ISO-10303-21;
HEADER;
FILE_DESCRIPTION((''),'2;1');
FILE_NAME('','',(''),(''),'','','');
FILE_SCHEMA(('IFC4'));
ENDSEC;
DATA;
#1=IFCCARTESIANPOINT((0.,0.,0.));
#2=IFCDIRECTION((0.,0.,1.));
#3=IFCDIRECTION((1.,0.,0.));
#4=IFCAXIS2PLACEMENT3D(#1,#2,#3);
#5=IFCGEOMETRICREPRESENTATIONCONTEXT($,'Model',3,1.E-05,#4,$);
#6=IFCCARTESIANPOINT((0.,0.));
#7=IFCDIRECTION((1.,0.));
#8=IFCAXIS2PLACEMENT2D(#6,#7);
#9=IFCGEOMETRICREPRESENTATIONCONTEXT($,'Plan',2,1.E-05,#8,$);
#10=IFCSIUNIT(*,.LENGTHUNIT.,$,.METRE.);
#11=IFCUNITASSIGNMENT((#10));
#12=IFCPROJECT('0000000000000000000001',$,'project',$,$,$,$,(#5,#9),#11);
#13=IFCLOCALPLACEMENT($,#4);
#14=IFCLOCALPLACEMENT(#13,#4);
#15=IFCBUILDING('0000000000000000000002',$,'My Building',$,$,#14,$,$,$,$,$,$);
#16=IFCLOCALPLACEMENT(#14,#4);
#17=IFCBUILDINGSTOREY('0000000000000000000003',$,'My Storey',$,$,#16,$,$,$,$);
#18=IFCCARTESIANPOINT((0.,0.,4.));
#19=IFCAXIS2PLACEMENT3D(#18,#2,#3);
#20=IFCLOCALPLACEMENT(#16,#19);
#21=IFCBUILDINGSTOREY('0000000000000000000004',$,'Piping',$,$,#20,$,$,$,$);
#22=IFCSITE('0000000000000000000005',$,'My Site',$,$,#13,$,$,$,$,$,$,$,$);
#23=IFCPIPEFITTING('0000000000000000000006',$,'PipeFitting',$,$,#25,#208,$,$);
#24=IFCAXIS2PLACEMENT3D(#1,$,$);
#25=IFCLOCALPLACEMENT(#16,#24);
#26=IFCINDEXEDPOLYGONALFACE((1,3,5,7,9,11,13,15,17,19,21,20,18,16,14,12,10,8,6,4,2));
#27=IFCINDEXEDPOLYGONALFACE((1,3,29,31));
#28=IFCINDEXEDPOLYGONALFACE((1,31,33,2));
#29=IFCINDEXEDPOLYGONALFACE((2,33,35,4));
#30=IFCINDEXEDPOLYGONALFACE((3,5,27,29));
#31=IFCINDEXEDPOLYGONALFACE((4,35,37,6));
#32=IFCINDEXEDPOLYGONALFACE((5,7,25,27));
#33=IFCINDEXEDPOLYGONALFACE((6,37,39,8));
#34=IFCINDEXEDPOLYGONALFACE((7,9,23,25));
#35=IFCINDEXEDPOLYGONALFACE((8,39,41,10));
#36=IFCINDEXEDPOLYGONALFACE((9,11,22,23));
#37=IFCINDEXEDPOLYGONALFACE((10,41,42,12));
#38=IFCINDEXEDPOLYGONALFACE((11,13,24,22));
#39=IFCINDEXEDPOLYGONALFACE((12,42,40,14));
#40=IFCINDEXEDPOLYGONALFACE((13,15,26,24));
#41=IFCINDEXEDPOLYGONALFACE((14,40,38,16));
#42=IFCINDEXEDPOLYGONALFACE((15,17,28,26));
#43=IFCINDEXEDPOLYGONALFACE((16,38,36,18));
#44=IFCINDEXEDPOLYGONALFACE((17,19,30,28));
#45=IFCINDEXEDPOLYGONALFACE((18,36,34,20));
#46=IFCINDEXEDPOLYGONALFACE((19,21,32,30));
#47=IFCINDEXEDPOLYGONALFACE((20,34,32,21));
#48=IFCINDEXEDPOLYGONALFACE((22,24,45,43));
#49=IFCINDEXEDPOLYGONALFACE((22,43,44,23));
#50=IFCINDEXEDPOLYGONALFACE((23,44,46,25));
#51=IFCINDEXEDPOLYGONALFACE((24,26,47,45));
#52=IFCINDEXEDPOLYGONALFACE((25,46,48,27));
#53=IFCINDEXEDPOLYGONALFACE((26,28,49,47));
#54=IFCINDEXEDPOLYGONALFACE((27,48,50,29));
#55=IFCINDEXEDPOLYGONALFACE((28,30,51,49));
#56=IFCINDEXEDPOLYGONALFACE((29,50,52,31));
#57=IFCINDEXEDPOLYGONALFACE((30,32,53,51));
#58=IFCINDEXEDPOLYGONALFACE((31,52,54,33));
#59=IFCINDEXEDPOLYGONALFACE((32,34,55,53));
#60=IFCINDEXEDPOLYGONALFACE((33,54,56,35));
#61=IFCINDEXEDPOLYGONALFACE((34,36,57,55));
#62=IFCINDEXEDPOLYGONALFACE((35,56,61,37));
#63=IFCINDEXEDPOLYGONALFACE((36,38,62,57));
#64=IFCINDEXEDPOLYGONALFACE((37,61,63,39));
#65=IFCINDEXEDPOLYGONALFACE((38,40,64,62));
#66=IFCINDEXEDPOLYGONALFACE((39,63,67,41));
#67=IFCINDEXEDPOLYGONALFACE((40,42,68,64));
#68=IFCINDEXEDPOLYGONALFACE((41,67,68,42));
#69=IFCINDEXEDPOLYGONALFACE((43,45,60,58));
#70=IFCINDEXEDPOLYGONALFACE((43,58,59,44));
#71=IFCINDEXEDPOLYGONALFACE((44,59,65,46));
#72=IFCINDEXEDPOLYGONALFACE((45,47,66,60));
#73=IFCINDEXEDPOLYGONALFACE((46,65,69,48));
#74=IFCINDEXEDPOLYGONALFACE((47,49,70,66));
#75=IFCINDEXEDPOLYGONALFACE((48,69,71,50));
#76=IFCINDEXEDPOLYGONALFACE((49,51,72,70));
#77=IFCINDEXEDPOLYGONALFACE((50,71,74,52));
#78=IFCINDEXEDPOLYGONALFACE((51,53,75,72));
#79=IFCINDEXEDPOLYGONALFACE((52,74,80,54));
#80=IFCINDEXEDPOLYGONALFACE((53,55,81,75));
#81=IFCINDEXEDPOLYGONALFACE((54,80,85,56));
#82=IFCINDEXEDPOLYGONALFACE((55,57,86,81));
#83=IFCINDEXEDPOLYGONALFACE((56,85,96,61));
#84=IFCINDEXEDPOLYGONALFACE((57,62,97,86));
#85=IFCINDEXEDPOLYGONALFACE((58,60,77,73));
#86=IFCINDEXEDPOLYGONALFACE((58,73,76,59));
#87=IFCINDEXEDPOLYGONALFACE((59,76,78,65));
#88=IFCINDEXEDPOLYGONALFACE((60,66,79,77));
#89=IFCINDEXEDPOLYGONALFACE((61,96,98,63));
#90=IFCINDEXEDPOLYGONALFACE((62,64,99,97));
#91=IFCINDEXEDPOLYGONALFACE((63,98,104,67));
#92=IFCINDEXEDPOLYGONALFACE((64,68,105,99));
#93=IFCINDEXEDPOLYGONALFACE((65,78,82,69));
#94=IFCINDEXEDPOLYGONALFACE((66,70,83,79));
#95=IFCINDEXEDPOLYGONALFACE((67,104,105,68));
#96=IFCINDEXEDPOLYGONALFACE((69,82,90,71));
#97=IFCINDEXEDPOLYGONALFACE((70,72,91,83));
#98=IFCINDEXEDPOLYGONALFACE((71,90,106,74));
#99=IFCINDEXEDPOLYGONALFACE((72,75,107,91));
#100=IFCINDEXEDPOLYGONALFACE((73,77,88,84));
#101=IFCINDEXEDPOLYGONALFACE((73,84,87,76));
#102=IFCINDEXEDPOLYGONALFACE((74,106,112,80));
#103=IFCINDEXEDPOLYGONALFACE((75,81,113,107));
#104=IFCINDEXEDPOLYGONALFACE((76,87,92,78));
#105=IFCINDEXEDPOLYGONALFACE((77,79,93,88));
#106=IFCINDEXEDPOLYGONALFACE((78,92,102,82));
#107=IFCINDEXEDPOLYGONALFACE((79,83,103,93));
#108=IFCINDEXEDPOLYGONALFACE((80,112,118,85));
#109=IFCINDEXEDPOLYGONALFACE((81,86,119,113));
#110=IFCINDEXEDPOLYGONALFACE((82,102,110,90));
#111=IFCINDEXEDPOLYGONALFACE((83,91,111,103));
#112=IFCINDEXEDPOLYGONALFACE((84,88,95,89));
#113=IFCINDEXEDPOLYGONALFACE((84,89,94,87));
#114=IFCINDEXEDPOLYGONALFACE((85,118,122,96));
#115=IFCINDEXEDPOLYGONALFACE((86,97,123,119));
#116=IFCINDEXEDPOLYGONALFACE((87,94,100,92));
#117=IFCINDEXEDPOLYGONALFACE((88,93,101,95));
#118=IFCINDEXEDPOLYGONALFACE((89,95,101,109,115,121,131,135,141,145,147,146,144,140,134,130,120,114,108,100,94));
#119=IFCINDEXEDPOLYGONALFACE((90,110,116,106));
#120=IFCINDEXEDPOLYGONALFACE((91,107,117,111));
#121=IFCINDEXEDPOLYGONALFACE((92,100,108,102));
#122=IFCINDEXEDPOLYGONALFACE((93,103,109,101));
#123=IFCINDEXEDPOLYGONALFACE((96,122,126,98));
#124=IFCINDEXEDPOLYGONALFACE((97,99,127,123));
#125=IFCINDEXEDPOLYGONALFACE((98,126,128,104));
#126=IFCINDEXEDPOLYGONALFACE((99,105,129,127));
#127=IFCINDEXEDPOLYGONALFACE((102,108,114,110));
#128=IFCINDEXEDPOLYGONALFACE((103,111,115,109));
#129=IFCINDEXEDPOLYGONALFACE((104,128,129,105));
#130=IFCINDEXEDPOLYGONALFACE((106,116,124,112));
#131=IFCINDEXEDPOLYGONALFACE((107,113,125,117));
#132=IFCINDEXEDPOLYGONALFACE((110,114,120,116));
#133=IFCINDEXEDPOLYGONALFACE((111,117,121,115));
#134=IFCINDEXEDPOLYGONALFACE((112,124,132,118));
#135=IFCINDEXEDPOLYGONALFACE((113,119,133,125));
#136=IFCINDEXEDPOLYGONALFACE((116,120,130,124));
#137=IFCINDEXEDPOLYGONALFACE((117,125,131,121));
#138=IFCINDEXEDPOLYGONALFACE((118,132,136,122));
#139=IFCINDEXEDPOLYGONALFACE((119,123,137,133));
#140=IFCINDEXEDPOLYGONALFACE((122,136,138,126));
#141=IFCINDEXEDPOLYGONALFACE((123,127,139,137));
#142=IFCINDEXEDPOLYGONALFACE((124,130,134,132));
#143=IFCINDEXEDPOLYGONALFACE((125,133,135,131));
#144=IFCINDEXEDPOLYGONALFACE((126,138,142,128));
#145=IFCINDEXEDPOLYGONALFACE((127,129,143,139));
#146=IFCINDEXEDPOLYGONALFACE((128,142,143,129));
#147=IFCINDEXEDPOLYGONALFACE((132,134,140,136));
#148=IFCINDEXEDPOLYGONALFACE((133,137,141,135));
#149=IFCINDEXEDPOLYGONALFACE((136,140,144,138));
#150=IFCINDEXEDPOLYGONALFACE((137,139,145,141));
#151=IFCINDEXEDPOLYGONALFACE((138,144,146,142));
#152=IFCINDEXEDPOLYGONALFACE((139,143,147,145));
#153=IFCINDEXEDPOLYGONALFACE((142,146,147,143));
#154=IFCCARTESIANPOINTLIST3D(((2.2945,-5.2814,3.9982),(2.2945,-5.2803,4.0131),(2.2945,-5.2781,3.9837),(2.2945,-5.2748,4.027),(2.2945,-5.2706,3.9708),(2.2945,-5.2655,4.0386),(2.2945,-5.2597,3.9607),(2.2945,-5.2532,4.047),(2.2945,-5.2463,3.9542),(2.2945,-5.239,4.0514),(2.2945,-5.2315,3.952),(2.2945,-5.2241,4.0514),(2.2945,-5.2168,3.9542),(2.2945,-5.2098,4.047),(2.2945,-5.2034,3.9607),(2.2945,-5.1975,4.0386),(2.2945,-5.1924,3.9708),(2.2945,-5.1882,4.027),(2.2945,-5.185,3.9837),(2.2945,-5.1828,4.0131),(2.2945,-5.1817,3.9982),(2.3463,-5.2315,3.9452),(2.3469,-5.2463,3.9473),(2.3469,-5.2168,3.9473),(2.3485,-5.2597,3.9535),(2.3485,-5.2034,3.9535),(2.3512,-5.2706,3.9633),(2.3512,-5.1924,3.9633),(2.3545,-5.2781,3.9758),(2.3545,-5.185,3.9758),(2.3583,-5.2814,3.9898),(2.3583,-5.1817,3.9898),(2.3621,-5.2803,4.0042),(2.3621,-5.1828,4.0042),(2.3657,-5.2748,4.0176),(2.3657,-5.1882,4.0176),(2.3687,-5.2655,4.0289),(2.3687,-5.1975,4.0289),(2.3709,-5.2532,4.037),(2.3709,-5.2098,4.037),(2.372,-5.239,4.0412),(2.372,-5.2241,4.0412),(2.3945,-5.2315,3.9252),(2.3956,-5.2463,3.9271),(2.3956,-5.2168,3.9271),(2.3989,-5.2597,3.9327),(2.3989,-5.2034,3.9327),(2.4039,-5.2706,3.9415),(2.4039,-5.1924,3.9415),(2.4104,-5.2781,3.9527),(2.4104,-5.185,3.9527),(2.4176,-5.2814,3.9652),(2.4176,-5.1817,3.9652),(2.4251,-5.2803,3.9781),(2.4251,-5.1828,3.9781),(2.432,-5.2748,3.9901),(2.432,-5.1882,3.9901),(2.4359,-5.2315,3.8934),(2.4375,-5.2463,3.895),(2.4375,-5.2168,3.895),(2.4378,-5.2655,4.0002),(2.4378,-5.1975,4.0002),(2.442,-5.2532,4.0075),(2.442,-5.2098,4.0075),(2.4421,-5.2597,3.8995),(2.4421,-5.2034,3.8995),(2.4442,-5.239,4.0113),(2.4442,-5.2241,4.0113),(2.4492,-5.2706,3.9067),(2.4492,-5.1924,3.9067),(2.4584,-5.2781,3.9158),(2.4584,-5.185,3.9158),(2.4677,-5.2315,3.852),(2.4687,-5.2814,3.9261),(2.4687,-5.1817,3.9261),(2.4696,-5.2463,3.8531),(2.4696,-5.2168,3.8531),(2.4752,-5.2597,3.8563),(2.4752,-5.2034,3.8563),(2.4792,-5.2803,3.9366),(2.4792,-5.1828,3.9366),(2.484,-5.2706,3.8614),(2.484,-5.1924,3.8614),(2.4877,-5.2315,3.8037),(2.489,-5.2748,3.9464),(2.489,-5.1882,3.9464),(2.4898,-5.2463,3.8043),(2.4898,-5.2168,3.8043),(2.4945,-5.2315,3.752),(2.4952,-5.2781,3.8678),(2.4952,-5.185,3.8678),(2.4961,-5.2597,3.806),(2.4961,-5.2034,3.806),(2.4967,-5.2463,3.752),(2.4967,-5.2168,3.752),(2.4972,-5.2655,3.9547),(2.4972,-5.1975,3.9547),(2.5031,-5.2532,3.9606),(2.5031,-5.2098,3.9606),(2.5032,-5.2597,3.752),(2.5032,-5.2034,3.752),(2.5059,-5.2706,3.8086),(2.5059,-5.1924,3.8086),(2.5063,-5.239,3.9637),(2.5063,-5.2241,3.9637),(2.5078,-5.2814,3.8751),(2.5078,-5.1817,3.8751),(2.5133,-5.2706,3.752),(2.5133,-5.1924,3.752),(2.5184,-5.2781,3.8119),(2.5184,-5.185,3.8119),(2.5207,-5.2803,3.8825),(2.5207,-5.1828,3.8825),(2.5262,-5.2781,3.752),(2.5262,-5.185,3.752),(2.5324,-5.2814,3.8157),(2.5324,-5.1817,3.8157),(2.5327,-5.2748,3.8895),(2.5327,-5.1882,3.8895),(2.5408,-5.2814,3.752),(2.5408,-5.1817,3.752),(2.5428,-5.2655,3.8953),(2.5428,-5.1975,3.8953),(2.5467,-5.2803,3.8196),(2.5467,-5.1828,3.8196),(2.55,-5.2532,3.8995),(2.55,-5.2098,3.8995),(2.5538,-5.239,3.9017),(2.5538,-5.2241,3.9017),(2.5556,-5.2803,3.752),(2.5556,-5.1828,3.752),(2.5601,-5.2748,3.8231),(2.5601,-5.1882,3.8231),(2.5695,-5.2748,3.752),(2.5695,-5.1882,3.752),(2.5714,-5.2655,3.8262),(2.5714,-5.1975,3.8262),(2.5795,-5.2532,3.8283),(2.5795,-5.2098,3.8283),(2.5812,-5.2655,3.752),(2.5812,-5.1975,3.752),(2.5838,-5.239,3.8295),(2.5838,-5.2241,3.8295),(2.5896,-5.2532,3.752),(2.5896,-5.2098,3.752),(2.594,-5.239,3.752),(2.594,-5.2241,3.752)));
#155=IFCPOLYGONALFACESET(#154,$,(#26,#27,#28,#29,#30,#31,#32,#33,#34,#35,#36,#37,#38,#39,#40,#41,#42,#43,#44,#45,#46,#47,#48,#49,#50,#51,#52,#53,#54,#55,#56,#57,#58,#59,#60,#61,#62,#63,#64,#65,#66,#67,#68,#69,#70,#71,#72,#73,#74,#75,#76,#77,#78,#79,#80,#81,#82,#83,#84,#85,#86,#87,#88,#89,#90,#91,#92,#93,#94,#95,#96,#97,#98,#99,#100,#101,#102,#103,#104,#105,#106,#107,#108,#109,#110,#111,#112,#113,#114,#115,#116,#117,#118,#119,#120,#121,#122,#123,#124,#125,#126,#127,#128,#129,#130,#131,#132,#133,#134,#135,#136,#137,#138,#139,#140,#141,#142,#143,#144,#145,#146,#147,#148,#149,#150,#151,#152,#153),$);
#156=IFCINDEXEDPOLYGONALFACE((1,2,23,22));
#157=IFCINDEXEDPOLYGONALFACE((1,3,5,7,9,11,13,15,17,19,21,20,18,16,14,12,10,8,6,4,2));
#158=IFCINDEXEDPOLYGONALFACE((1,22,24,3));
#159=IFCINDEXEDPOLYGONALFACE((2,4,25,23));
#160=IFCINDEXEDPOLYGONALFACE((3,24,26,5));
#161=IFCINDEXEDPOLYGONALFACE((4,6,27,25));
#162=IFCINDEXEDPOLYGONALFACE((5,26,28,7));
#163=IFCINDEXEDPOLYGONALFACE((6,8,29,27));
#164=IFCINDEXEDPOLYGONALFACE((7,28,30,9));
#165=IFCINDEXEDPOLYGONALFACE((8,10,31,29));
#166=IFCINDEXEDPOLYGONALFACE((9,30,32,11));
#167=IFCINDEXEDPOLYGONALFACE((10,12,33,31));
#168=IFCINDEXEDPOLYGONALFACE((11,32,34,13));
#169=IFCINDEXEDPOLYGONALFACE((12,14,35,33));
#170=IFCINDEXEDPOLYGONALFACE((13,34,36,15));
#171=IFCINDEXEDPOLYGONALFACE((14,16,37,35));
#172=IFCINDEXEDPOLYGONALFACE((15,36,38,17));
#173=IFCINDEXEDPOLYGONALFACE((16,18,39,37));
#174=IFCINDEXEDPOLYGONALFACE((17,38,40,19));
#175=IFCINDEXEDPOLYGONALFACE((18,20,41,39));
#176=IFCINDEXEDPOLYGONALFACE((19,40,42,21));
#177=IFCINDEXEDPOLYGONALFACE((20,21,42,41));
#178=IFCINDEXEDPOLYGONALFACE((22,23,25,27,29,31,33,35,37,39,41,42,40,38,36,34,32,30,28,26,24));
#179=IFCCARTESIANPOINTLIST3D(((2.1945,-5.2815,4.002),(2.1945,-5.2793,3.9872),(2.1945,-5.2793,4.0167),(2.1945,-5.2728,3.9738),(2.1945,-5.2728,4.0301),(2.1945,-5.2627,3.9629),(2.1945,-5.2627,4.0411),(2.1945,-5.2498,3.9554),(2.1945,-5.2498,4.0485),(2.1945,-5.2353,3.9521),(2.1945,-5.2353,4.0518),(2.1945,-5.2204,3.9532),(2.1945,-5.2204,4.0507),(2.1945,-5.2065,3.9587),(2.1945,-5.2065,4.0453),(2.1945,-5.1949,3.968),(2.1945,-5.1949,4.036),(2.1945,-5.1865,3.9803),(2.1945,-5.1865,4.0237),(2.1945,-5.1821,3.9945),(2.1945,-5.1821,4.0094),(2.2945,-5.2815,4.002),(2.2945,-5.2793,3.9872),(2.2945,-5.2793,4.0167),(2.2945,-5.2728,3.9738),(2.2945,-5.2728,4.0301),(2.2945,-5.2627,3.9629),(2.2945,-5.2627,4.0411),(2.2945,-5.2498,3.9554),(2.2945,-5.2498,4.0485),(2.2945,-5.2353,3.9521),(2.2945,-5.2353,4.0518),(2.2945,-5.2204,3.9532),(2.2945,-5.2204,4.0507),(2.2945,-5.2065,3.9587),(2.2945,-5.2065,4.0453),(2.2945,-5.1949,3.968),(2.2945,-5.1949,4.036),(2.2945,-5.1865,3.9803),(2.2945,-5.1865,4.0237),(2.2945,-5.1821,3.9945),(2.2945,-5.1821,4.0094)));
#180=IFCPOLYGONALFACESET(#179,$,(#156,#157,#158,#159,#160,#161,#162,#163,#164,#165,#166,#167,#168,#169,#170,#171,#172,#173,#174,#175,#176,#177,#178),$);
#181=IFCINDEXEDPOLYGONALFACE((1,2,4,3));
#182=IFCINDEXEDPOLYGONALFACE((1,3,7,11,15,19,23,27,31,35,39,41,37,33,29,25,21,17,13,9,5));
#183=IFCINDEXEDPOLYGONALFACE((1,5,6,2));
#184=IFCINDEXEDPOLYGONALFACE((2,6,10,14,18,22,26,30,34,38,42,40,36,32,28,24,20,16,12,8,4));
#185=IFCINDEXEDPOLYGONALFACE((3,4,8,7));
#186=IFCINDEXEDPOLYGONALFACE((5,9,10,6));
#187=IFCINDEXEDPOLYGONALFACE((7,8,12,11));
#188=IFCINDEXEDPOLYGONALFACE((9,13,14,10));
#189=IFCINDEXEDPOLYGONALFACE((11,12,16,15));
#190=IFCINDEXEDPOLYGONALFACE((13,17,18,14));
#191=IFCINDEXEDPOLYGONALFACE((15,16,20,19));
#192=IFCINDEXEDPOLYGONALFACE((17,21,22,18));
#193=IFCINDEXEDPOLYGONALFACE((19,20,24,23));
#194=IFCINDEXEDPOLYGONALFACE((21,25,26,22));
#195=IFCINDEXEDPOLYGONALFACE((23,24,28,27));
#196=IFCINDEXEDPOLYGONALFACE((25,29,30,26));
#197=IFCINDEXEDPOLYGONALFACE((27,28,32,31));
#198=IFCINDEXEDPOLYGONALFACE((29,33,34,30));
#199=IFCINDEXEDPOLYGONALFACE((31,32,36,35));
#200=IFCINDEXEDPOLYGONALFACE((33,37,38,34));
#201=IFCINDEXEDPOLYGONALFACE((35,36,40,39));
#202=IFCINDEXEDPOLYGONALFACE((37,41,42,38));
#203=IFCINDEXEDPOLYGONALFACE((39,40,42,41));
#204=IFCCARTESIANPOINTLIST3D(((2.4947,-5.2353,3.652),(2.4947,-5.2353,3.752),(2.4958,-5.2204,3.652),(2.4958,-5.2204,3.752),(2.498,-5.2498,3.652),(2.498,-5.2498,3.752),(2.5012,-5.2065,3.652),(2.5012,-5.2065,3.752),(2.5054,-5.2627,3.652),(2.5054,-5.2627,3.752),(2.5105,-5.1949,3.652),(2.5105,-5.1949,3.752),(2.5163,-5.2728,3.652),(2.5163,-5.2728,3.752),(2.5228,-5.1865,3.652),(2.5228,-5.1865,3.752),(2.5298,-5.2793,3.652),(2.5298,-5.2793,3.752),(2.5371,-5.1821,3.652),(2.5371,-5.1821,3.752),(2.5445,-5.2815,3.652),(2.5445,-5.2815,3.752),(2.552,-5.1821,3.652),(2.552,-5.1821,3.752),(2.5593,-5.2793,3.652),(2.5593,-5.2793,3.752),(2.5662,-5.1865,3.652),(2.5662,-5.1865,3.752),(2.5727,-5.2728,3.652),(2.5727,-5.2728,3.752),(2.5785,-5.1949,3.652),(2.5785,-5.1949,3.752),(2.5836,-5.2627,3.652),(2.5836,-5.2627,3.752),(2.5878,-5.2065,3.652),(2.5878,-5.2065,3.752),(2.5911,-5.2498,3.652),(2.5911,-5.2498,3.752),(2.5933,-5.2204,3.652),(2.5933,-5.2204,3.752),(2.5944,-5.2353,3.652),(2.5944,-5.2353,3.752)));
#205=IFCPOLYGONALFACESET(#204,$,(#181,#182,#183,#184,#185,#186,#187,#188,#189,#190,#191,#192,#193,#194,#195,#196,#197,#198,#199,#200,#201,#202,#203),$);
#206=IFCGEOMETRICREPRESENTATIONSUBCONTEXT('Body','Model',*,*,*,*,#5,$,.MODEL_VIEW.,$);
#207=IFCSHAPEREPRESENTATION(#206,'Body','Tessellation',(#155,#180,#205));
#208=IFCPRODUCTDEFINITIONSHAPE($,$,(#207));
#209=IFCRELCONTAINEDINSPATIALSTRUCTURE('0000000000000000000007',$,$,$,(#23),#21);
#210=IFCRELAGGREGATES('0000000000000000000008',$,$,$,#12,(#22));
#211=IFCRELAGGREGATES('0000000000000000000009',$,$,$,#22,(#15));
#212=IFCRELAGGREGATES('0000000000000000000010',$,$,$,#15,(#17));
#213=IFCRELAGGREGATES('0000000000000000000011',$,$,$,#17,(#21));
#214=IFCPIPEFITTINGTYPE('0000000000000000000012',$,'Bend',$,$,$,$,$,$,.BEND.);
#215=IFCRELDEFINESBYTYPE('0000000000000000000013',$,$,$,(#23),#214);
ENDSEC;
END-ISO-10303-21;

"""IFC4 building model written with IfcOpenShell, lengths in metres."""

from ifc_helpers import new_model, entity, si_unit, frame, origin_with_axes, origin_2d_with_axis, place, context, subcontext, project, spatial, circle, extrude, source, transform, mapped, type_object, type_shapes, element, save


model = new_model("IFC4")

# Units and contexts
model_context = context("Model", 3, precision=1e-05, world=origin_with_axes())
plan_context = context("Plan", 2, precision=1e-05, world=origin_2d_with_axis())
body_context = subcontext(model_context, "Body", "Model", "MODEL_VIEW")
ifc_project = project(units=[si_unit("LENGTHUNIT", "METRE")], contexts=[model_context, plan_context])

# Site, building, storeys
site_placement = place(None, origin_with_axes())
site = spatial("IfcSite", under=ifc_project, at=site_placement, Name="My Site")
building_placement = place(site_placement, origin_with_axes())
building = spatial("IfcBuilding", under=site, at=building_placement, Name="My Building")
storey_1_placement = place(building_placement, origin_with_axes())
storey_1 = spatial("IfcBuildingStorey", under=building, at=storey_1_placement, Name="My Storey")
storey_2_placement = place(storey_1_placement, frame((0.0, 0.0, 4.0), z_axis=(0.0, 0.0, 1.0), x_axis=(1.0, 0.0, 0.0)))
storey_2 = spatial("IfcBuildingStorey", under=storey_1, at=storey_2_placement, Name="Piping")

# Shared definitions
pipe_fitting_type_1 = type_object("IfcPipeFittingType", Name="Bend", PredefinedType="BEND")
shared_shape = source(origin_with_axes(), body_context, "Body", "SolidModel", [
    entity("IfcSweptDiskSolid", entity("IfcIndexedPolyCurve", entity("IfcCartesianPointList3D", [[0.0, 0.0, -0.1], [0.0, -0.0732, -0.2768], [0.0, -0.25, -0.35]]), [entity("IfcArcIndex", [1, 2, 3])]), 0.05),
    extrude(circle(Radius=0.05), origin_with_axes(), (0.0, 0.0, -1.0), 0.1),
    extrude(circle(Radius=0.05), frame((0.0, -0.25, -0.35), z_axis=(0.0, -1.0, 0.0), x_axis=(1.0, 0.0, 0.0)), (0.0, 0.0, 1.0), 0.1),
])
type_shapes(pipe_fitting_type_1, [shared_shape])

# Pipe fitting
pipe_fitting_1_placement = place(storey_2_placement, frame((2.1945, -5.2315, 0.002), z_axis=(-1.0, 0.0, -0.000001), x_axis=(0.0, -1.0, 0.0)))
element("IfcPipeFitting", 1, at=pipe_fitting_1_placement, inside=storey_2, type_object=pipe_fitting_type_1, Name="PipeFitting", context=body_context, shape_type="MappedRepresentation", body=[
    mapped(shared_shape, transform((0.0, 0.0, 0.0), x_axis=(1.0, 0.0, 0.0), y_axis=(0.0, 1.0, 0.0), z_axis=(0.0, 0.0, 1.0), scale=1.0)),
])

save(model, "model.ifc")
